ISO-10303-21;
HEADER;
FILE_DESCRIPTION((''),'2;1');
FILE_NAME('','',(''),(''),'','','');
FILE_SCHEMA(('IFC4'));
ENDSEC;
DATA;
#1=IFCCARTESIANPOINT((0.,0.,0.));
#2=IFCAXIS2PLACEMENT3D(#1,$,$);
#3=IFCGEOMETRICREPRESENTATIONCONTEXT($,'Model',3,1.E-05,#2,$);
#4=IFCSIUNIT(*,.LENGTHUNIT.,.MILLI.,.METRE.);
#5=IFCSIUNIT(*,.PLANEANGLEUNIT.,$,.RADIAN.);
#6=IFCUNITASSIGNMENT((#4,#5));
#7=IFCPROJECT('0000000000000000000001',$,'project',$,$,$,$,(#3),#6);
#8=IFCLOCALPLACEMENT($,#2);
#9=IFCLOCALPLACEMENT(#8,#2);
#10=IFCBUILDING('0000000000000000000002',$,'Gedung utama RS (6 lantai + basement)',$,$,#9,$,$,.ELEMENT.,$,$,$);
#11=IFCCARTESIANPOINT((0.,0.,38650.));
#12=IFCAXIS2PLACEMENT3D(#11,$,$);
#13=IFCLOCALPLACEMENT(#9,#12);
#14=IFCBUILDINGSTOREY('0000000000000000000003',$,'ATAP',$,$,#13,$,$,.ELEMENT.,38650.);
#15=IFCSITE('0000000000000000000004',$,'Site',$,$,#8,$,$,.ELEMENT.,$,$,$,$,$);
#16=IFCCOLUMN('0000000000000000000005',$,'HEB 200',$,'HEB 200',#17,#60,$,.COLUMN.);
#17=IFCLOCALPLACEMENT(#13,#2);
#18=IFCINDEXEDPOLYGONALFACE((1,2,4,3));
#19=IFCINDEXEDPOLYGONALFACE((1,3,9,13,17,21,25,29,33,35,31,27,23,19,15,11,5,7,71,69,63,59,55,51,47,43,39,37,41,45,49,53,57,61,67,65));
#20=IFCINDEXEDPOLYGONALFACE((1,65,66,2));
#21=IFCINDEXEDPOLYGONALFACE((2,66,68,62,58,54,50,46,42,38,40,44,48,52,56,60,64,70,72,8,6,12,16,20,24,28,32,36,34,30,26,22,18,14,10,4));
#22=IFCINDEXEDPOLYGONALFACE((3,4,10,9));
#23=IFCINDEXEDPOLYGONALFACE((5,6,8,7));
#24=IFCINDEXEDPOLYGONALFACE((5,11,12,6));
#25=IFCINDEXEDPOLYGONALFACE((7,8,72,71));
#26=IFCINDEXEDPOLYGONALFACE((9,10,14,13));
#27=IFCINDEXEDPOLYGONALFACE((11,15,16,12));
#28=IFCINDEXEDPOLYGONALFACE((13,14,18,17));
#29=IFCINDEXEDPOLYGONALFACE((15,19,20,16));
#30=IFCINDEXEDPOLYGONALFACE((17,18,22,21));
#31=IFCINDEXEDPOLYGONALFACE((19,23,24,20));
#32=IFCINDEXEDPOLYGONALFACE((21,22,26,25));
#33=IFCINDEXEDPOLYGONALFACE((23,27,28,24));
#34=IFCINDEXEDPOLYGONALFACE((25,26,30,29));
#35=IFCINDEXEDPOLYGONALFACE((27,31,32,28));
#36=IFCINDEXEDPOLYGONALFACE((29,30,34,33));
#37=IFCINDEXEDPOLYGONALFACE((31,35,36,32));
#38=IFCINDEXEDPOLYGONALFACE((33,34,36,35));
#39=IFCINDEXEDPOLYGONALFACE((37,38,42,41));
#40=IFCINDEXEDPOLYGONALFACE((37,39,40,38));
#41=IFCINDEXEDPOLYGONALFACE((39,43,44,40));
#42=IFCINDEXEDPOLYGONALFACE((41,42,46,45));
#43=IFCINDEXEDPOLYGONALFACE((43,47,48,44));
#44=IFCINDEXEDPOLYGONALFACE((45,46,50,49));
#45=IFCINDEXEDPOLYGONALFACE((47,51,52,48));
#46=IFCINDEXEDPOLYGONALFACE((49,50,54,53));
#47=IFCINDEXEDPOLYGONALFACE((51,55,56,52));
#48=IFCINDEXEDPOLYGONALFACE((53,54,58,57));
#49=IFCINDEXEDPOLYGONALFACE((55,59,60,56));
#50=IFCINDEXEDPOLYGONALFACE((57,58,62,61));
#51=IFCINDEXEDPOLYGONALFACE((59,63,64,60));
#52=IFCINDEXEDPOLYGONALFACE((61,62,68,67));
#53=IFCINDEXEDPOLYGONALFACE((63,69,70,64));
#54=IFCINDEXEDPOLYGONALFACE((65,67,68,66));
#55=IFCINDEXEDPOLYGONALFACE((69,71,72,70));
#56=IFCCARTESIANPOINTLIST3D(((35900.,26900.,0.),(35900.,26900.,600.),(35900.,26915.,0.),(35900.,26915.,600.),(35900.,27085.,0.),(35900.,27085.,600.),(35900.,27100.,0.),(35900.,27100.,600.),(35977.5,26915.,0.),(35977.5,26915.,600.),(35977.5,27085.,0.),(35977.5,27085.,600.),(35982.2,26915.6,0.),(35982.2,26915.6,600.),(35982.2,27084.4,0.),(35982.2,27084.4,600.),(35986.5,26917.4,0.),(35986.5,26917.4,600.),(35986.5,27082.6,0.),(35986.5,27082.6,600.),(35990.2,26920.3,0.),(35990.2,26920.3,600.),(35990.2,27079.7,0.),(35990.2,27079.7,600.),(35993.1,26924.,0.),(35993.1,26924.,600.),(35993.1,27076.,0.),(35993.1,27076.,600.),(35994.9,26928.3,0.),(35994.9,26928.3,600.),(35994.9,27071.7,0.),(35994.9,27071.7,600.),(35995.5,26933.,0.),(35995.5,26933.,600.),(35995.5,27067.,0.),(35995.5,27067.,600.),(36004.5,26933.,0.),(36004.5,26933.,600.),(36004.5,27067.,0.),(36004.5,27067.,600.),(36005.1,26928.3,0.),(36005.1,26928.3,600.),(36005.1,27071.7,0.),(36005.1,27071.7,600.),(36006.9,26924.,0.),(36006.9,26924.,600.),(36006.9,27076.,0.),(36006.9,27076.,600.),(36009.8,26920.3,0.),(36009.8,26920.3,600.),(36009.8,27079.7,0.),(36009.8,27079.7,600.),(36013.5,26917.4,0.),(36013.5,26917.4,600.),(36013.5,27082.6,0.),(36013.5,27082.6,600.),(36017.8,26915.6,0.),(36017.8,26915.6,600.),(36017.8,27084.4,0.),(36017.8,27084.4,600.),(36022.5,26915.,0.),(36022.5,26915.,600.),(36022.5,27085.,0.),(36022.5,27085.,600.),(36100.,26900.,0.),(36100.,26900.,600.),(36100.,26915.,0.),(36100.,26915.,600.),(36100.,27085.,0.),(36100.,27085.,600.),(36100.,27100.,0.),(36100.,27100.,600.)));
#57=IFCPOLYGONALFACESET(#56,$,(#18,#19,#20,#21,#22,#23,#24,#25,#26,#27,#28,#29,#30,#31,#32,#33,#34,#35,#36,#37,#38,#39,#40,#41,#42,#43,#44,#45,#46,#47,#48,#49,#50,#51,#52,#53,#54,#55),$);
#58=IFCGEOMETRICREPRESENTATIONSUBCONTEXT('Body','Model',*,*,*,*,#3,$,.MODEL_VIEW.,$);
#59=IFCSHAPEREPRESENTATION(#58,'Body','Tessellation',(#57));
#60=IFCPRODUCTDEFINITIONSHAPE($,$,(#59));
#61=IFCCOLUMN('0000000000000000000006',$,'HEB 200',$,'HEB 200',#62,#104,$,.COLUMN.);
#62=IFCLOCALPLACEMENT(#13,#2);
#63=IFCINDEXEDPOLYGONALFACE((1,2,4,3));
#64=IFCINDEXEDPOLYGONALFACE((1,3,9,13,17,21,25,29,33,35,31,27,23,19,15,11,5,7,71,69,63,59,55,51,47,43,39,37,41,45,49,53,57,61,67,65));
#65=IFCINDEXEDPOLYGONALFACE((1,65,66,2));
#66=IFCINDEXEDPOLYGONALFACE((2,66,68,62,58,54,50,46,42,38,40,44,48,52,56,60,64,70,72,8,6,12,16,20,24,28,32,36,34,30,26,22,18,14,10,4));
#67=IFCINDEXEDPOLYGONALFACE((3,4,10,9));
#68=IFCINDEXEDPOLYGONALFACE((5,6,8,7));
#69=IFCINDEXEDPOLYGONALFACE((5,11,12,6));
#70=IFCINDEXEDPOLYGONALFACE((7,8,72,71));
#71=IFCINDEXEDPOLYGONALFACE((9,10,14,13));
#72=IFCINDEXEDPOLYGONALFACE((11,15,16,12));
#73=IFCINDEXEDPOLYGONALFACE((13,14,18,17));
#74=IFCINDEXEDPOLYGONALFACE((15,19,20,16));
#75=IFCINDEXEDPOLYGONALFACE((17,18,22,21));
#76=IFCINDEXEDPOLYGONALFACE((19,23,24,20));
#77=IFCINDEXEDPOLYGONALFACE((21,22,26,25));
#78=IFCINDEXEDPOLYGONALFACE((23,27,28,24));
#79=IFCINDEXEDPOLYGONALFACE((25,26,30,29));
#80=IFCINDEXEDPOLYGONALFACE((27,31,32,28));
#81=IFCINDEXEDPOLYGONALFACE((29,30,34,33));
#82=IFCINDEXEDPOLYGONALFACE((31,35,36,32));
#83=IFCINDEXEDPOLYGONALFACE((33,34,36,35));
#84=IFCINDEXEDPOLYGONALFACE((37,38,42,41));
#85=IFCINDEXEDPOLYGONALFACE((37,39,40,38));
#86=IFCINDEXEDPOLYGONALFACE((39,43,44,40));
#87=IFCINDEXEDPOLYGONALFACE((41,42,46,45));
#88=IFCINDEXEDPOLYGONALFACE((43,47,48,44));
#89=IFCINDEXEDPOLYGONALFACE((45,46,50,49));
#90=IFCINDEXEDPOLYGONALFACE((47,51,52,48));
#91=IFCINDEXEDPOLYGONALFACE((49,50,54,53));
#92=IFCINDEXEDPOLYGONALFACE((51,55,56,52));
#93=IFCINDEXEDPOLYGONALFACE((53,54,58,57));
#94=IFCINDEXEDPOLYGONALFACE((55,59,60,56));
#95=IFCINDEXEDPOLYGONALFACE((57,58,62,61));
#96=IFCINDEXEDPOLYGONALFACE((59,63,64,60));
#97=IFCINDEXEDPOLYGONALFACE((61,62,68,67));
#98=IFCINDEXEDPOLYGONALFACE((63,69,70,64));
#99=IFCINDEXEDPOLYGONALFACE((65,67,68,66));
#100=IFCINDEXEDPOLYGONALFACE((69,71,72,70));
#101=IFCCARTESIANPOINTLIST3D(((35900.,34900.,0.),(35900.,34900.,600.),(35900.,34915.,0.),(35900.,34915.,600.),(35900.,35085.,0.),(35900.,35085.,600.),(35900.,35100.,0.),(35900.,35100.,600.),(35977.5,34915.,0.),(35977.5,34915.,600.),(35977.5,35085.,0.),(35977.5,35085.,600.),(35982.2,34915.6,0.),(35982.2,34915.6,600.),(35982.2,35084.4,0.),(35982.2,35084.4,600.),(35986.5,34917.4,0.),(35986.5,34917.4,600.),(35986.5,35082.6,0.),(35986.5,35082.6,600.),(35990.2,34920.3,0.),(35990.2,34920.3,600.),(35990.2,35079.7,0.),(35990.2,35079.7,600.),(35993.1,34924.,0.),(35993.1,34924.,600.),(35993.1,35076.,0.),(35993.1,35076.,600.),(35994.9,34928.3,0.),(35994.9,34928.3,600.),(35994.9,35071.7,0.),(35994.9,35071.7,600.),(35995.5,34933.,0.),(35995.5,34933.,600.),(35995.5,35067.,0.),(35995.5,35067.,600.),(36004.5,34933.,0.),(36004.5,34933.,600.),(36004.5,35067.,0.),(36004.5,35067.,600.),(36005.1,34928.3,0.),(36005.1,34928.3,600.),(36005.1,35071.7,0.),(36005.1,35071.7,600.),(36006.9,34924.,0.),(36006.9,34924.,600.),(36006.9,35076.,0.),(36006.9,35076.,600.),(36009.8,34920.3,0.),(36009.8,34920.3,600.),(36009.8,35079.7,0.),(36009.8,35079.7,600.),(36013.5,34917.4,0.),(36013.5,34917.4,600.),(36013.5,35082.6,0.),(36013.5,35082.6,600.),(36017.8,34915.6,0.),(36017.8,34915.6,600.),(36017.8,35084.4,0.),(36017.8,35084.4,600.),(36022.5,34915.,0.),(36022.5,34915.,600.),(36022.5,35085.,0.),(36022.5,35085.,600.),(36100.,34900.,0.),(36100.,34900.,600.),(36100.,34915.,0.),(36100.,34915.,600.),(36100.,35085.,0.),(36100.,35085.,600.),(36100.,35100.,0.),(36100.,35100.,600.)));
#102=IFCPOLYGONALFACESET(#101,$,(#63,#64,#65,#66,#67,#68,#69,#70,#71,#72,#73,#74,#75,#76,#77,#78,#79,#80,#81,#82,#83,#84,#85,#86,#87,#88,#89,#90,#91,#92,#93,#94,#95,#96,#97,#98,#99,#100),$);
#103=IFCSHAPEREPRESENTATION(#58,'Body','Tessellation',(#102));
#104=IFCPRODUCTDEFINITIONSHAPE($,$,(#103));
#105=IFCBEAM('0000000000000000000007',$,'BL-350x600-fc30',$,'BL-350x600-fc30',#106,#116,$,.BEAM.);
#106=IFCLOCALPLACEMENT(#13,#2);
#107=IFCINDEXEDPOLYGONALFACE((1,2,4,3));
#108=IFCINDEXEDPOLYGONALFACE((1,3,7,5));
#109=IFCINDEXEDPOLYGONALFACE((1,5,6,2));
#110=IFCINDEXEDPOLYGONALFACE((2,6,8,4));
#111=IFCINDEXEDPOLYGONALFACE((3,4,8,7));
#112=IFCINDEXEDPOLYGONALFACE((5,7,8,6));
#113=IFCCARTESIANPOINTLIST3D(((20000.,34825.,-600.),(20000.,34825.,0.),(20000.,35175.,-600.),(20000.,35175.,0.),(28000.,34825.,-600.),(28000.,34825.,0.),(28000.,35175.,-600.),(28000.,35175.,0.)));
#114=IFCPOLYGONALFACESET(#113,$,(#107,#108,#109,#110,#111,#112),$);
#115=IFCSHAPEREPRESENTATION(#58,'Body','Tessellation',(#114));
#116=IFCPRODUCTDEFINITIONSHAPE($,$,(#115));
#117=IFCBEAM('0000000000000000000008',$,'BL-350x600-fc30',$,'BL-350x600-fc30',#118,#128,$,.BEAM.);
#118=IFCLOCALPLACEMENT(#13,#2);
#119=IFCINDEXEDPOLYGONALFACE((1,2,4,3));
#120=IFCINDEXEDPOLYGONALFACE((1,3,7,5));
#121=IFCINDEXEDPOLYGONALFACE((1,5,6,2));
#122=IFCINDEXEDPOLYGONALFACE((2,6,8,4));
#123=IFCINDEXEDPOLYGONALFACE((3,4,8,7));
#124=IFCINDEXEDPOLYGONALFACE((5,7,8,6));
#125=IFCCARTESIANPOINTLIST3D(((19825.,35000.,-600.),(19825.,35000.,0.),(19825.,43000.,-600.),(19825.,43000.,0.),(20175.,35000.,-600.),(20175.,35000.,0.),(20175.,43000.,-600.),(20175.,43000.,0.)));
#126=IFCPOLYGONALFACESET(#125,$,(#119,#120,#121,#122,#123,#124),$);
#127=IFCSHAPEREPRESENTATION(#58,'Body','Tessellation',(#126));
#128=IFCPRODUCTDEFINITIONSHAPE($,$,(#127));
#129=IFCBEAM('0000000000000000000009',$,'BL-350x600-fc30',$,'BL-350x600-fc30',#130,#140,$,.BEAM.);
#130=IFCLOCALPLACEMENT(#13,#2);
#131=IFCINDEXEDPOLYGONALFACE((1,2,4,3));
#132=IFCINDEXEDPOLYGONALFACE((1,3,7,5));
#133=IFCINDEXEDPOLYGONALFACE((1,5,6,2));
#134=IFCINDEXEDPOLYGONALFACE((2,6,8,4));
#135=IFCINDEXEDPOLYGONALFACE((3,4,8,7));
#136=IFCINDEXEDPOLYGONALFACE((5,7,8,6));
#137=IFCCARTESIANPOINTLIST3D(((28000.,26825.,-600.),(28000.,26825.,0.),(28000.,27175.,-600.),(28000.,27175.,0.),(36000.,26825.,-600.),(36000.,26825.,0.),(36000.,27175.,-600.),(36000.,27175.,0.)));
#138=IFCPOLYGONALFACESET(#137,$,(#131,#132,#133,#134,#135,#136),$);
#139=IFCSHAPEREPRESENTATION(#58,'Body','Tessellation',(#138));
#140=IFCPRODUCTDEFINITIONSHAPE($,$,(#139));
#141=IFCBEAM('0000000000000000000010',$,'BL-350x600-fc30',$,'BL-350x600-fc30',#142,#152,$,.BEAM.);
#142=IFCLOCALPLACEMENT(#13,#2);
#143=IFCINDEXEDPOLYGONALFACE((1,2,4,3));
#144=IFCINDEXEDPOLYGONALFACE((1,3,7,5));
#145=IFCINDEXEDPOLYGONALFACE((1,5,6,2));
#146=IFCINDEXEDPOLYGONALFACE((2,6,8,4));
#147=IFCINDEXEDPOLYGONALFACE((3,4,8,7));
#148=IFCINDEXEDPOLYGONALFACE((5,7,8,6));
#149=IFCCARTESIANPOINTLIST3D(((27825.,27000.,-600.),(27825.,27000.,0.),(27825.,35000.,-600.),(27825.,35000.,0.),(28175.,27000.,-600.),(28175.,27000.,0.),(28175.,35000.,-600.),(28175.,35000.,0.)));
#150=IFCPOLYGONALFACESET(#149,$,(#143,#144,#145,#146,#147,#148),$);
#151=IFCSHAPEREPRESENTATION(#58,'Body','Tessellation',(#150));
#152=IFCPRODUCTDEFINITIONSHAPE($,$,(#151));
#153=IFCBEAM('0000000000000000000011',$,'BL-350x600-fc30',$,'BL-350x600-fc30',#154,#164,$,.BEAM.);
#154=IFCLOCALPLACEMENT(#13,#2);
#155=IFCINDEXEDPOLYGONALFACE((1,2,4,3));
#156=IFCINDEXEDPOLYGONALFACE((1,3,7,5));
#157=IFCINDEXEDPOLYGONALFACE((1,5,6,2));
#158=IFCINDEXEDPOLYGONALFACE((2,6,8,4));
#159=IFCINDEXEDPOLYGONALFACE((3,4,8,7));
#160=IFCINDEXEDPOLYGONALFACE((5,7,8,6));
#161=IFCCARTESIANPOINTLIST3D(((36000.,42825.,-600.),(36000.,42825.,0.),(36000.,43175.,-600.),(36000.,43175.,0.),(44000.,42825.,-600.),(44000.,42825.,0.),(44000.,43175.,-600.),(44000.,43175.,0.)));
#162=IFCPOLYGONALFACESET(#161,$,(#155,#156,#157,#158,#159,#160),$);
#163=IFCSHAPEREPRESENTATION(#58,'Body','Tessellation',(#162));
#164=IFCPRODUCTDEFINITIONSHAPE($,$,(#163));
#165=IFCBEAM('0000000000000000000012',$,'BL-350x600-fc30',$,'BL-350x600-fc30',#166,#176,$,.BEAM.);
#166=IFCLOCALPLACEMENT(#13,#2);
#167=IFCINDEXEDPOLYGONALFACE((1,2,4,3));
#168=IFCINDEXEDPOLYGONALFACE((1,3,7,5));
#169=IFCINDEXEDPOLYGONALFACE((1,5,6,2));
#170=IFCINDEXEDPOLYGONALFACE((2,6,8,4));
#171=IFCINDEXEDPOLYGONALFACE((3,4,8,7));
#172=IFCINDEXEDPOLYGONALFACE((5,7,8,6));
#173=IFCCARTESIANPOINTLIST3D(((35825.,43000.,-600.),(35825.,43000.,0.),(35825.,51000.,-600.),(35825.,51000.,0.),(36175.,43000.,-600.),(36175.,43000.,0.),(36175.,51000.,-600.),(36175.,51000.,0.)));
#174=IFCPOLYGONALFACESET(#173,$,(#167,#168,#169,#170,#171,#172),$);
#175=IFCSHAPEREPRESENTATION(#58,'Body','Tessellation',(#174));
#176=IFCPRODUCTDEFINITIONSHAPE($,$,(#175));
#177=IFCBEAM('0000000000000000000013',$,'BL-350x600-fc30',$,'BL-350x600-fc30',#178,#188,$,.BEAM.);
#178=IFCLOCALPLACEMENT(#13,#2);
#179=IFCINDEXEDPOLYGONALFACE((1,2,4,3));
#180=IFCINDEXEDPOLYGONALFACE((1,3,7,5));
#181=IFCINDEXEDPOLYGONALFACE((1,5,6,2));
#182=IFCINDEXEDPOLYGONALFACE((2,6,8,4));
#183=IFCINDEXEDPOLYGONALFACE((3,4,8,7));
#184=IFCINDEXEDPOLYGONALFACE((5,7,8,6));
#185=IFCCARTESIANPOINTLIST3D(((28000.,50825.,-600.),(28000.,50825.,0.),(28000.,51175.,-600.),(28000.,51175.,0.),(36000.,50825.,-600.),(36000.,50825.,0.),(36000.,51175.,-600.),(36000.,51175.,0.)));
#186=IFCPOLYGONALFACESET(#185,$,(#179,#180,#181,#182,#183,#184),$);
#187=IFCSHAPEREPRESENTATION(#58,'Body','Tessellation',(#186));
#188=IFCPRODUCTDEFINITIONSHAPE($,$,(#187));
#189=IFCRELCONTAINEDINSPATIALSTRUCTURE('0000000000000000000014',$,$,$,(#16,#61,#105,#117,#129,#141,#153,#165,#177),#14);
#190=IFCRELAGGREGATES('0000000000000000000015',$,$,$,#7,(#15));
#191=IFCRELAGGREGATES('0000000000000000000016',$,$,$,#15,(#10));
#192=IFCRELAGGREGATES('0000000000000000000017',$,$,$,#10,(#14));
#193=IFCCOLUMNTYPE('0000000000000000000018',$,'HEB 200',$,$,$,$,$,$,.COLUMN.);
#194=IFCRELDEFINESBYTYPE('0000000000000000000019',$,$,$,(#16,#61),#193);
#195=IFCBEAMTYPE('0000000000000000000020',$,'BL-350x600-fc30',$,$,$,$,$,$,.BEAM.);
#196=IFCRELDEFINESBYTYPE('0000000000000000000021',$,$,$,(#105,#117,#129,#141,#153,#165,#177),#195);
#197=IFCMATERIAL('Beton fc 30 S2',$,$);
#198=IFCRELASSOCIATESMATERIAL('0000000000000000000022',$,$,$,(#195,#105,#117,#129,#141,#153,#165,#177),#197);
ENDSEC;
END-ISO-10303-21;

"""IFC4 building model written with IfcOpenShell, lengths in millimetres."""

from ifc_helpers import new_model, si_unit, frame, origin, origin_2d, place, context, subcontext, project, spatial, rectangle, i_section, extrude, material, material_profile, profile_set, profile_usage, type_object, element, save


model = new_model("IFC4")

# Units and contexts
model_context = context("Model", 3, precision=1e-05, world=origin())
body_context = subcontext(model_context, "Body", "Model", "MODEL_VIEW")
ifc_project = project(units=[si_unit("LENGTHUNIT", "METRE", prefix="MILLI"), si_unit("PLANEANGLEUNIT", "RADIAN")], contexts=[model_context])

# Site, building, storey
site_placement = place(None, origin())
site = spatial("IfcSite", under=ifc_project, at=site_placement, Name="Site", CompositionType="ELEMENT")
building_placement = place(site_placement, origin())
building = spatial("IfcBuilding", under=site, at=building_placement, Name="Gedung utama RS (6 lantai + basement)", CompositionType="ELEMENT")
storey_placement = place(building_placement, frame((0.0, 0.0, 38650.0)))
storey = spatial("IfcBuildingStorey", under=building, at=storey_placement, Name="ATAP", CompositionType="ELEMENT", Elevation=38650.0)

# Columns
ifc_material_profile_1 = material_profile(None, i_section(OverallWidth=200.0, OverallDepth=200.0, WebThickness=9.0, FlangeThickness=15.0, FilletRadius=18.0, at=origin_2d()), Name="HEB 200")
ifc_profile_set_1 = profile_set([ifc_material_profile_1], Name="HEB 200")
ifc_profile_usage_1 = profile_usage(ifc_profile_set_1, cardinal=5)
column_type = type_object("IfcColumnType", Name="HEB 200", PredefinedType="COLUMN", material=ifc_profile_set_1)
for number, where, z_axis, x_axis, name in (
    (1, (36000.0, 27000.0, 0.0), (0.0, 0.0, 1.0), (1.0, 0.0, 0.0), "HEB 200"),
    (2, (36000.0, 35000.0, 0.0), (0.0, 0.0, 1.0), (1.0, 0.0, 0.0), "HEB 200"),
):
    element("IfcColumn", number, at=place(storey_placement, frame(where, z_axis=z_axis, x_axis=x_axis)), inside=storey, type_object=column_type, material=ifc_profile_usage_1, Name=name, ObjectType="HEB 200", PredefinedType="COLUMN", context=body_context, shape_type="SweptSolid", body=[
        extrude(i_section(OverallWidth=200.0, OverallDepth=200.0, WebThickness=9.0, FlangeThickness=15.0, FilletRadius=18.0, at=origin_2d()), origin(), (0.0, 0.0, 1.0), 600.0),
    ])

# Beams
ifc_material = material(Name="Beton fc 30 S2")
ifc_material_profile_2 = material_profile(ifc_material, rectangle(XDim=350.0, YDim=600.0, at=origin_2d()), Name="BL-350x600-fc30")
ifc_profile_set_2 = profile_set([ifc_material_profile_2], Name="BL-350x600-fc30")
ifc_profile_usage_2 = profile_usage(ifc_profile_set_2, cardinal=8)
beam_type = type_object("IfcBeamType", Name="BL-350x600-fc30", PredefinedType="BEAM", material=ifc_profile_set_2)
beam_1_placement = place(storey_placement, frame((20000.0, 35000.0, -300.0)))
element("IfcBeam", 3, at=beam_1_placement, inside=storey, type_object=beam_type, material=ifc_profile_usage_2, Name="BL-350x600-fc30", ObjectType="BL-350x600-fc30", PredefinedType="BEAM", context=body_context, shape_type="SweptSolid", body=[
    extrude(rectangle(XDim=350.0, YDim=600.0, at=origin_2d()), frame((0.0, 0.0, 0.0), z_axis=(1.0, 0.0, 0.0), x_axis=(0.0, 1.0, 0.0)), (0.0, 0.0, 1.0), 8000.0),
])
beam_2_placement = place(storey_placement, frame((20000.0, 35000.0, -300.0)))
element("IfcBeam", 4, at=beam_2_placement, inside=storey, type_object=beam_type, material=ifc_profile_usage_2, Name="BL-350x600-fc30", ObjectType="BL-350x600-fc30", PredefinedType="BEAM", context=body_context, shape_type="SweptSolid", body=[
    extrude(rectangle(XDim=350.0, YDim=600.0, at=origin_2d()), frame((0.0, 0.0, 0.0), z_axis=(0.0, 1.0, 0.0), x_axis=(-1.0, 0.0, 0.0)), (0.0, 0.0, 1.0), 8000.0),
])
beam_3_placement = place(storey_placement, frame((28000.0, 27000.0, -300.0)))
element("IfcBeam", 5, at=beam_3_placement, inside=storey, type_object=beam_type, material=ifc_profile_usage_2, Name="BL-350x600-fc30", ObjectType="BL-350x600-fc30", PredefinedType="BEAM", context=body_context, shape_type="SweptSolid", body=[
    extrude(rectangle(XDim=350.0, YDim=600.0, at=origin_2d()), frame((0.0, 0.0, 0.0), z_axis=(1.0, 0.0, 0.0), x_axis=(0.0, 1.0, 0.0)), (0.0, 0.0, 1.0), 8000.0),
])
beam_4_placement = place(storey_placement, frame((28000.0, 27000.0, -300.0)))
element("IfcBeam", 6, at=beam_4_placement, inside=storey, type_object=beam_type, material=ifc_profile_usage_2, Name="BL-350x600-fc30", ObjectType="BL-350x600-fc30", PredefinedType="BEAM", context=body_context, shape_type="SweptSolid", body=[
    extrude(rectangle(XDim=350.0, YDim=600.0, at=origin_2d()), frame((0.0, 0.0, 0.0), z_axis=(0.0, 1.0, 0.0), x_axis=(-1.0, 0.0, 0.0)), (0.0, 0.0, 1.0), 8000.0),
])
beam_5_placement = place(storey_placement, frame((36000.0, 43000.0, -300.0)))
element("IfcBeam", 7, at=beam_5_placement, inside=storey, type_object=beam_type, material=ifc_profile_usage_2, Name="BL-350x600-fc30", ObjectType="BL-350x600-fc30", PredefinedType="BEAM", context=body_context, shape_type="SweptSolid", body=[
    extrude(rectangle(XDim=350.0, YDim=600.0, at=origin_2d()), frame((0.0, 0.0, 0.0), z_axis=(1.0, 0.0, 0.0), x_axis=(0.0, 1.0, 0.0)), (0.0, 0.0, 1.0), 8000.0),
])
beam_6_placement = place(storey_placement, frame((36000.0, 43000.0, -300.0)))
element("IfcBeam", 8, at=beam_6_placement, inside=storey, type_object=beam_type, material=ifc_profile_usage_2, Name="BL-350x600-fc30", ObjectType="BL-350x600-fc30", PredefinedType="BEAM", context=body_context, shape_type="SweptSolid", body=[
    extrude(rectangle(XDim=350.0, YDim=600.0, at=origin_2d()), frame((0.0, 0.0, 0.0), z_axis=(0.0, 1.0, 0.0), x_axis=(-1.0, 0.0, 0.0)), (0.0, 0.0, 1.0), 8000.0),
])
for number, where, name in (
    (9, (28000.0, 51000.0, -300.0), "BL-350x600-fc30"),
):
    element("IfcBeam", number, at=place(storey_placement, frame(where)), inside=storey, type_object=beam_type, material=ifc_profile_usage_2, Name=name, ObjectType="BL-350x600-fc30", PredefinedType="BEAM", context=body_context, shape_type="SweptSolid", body=[
        extrude(rectangle(XDim=350.0, YDim=600.0, at=origin_2d()), frame((0.0, 0.0, 0.0), z_axis=(1.0, 0.0, 0.0), x_axis=(0.0, 1.0, 0.0)), (0.0, 0.0, 1.0), 8000.0),
    ])

save(model, "model.ifc")
